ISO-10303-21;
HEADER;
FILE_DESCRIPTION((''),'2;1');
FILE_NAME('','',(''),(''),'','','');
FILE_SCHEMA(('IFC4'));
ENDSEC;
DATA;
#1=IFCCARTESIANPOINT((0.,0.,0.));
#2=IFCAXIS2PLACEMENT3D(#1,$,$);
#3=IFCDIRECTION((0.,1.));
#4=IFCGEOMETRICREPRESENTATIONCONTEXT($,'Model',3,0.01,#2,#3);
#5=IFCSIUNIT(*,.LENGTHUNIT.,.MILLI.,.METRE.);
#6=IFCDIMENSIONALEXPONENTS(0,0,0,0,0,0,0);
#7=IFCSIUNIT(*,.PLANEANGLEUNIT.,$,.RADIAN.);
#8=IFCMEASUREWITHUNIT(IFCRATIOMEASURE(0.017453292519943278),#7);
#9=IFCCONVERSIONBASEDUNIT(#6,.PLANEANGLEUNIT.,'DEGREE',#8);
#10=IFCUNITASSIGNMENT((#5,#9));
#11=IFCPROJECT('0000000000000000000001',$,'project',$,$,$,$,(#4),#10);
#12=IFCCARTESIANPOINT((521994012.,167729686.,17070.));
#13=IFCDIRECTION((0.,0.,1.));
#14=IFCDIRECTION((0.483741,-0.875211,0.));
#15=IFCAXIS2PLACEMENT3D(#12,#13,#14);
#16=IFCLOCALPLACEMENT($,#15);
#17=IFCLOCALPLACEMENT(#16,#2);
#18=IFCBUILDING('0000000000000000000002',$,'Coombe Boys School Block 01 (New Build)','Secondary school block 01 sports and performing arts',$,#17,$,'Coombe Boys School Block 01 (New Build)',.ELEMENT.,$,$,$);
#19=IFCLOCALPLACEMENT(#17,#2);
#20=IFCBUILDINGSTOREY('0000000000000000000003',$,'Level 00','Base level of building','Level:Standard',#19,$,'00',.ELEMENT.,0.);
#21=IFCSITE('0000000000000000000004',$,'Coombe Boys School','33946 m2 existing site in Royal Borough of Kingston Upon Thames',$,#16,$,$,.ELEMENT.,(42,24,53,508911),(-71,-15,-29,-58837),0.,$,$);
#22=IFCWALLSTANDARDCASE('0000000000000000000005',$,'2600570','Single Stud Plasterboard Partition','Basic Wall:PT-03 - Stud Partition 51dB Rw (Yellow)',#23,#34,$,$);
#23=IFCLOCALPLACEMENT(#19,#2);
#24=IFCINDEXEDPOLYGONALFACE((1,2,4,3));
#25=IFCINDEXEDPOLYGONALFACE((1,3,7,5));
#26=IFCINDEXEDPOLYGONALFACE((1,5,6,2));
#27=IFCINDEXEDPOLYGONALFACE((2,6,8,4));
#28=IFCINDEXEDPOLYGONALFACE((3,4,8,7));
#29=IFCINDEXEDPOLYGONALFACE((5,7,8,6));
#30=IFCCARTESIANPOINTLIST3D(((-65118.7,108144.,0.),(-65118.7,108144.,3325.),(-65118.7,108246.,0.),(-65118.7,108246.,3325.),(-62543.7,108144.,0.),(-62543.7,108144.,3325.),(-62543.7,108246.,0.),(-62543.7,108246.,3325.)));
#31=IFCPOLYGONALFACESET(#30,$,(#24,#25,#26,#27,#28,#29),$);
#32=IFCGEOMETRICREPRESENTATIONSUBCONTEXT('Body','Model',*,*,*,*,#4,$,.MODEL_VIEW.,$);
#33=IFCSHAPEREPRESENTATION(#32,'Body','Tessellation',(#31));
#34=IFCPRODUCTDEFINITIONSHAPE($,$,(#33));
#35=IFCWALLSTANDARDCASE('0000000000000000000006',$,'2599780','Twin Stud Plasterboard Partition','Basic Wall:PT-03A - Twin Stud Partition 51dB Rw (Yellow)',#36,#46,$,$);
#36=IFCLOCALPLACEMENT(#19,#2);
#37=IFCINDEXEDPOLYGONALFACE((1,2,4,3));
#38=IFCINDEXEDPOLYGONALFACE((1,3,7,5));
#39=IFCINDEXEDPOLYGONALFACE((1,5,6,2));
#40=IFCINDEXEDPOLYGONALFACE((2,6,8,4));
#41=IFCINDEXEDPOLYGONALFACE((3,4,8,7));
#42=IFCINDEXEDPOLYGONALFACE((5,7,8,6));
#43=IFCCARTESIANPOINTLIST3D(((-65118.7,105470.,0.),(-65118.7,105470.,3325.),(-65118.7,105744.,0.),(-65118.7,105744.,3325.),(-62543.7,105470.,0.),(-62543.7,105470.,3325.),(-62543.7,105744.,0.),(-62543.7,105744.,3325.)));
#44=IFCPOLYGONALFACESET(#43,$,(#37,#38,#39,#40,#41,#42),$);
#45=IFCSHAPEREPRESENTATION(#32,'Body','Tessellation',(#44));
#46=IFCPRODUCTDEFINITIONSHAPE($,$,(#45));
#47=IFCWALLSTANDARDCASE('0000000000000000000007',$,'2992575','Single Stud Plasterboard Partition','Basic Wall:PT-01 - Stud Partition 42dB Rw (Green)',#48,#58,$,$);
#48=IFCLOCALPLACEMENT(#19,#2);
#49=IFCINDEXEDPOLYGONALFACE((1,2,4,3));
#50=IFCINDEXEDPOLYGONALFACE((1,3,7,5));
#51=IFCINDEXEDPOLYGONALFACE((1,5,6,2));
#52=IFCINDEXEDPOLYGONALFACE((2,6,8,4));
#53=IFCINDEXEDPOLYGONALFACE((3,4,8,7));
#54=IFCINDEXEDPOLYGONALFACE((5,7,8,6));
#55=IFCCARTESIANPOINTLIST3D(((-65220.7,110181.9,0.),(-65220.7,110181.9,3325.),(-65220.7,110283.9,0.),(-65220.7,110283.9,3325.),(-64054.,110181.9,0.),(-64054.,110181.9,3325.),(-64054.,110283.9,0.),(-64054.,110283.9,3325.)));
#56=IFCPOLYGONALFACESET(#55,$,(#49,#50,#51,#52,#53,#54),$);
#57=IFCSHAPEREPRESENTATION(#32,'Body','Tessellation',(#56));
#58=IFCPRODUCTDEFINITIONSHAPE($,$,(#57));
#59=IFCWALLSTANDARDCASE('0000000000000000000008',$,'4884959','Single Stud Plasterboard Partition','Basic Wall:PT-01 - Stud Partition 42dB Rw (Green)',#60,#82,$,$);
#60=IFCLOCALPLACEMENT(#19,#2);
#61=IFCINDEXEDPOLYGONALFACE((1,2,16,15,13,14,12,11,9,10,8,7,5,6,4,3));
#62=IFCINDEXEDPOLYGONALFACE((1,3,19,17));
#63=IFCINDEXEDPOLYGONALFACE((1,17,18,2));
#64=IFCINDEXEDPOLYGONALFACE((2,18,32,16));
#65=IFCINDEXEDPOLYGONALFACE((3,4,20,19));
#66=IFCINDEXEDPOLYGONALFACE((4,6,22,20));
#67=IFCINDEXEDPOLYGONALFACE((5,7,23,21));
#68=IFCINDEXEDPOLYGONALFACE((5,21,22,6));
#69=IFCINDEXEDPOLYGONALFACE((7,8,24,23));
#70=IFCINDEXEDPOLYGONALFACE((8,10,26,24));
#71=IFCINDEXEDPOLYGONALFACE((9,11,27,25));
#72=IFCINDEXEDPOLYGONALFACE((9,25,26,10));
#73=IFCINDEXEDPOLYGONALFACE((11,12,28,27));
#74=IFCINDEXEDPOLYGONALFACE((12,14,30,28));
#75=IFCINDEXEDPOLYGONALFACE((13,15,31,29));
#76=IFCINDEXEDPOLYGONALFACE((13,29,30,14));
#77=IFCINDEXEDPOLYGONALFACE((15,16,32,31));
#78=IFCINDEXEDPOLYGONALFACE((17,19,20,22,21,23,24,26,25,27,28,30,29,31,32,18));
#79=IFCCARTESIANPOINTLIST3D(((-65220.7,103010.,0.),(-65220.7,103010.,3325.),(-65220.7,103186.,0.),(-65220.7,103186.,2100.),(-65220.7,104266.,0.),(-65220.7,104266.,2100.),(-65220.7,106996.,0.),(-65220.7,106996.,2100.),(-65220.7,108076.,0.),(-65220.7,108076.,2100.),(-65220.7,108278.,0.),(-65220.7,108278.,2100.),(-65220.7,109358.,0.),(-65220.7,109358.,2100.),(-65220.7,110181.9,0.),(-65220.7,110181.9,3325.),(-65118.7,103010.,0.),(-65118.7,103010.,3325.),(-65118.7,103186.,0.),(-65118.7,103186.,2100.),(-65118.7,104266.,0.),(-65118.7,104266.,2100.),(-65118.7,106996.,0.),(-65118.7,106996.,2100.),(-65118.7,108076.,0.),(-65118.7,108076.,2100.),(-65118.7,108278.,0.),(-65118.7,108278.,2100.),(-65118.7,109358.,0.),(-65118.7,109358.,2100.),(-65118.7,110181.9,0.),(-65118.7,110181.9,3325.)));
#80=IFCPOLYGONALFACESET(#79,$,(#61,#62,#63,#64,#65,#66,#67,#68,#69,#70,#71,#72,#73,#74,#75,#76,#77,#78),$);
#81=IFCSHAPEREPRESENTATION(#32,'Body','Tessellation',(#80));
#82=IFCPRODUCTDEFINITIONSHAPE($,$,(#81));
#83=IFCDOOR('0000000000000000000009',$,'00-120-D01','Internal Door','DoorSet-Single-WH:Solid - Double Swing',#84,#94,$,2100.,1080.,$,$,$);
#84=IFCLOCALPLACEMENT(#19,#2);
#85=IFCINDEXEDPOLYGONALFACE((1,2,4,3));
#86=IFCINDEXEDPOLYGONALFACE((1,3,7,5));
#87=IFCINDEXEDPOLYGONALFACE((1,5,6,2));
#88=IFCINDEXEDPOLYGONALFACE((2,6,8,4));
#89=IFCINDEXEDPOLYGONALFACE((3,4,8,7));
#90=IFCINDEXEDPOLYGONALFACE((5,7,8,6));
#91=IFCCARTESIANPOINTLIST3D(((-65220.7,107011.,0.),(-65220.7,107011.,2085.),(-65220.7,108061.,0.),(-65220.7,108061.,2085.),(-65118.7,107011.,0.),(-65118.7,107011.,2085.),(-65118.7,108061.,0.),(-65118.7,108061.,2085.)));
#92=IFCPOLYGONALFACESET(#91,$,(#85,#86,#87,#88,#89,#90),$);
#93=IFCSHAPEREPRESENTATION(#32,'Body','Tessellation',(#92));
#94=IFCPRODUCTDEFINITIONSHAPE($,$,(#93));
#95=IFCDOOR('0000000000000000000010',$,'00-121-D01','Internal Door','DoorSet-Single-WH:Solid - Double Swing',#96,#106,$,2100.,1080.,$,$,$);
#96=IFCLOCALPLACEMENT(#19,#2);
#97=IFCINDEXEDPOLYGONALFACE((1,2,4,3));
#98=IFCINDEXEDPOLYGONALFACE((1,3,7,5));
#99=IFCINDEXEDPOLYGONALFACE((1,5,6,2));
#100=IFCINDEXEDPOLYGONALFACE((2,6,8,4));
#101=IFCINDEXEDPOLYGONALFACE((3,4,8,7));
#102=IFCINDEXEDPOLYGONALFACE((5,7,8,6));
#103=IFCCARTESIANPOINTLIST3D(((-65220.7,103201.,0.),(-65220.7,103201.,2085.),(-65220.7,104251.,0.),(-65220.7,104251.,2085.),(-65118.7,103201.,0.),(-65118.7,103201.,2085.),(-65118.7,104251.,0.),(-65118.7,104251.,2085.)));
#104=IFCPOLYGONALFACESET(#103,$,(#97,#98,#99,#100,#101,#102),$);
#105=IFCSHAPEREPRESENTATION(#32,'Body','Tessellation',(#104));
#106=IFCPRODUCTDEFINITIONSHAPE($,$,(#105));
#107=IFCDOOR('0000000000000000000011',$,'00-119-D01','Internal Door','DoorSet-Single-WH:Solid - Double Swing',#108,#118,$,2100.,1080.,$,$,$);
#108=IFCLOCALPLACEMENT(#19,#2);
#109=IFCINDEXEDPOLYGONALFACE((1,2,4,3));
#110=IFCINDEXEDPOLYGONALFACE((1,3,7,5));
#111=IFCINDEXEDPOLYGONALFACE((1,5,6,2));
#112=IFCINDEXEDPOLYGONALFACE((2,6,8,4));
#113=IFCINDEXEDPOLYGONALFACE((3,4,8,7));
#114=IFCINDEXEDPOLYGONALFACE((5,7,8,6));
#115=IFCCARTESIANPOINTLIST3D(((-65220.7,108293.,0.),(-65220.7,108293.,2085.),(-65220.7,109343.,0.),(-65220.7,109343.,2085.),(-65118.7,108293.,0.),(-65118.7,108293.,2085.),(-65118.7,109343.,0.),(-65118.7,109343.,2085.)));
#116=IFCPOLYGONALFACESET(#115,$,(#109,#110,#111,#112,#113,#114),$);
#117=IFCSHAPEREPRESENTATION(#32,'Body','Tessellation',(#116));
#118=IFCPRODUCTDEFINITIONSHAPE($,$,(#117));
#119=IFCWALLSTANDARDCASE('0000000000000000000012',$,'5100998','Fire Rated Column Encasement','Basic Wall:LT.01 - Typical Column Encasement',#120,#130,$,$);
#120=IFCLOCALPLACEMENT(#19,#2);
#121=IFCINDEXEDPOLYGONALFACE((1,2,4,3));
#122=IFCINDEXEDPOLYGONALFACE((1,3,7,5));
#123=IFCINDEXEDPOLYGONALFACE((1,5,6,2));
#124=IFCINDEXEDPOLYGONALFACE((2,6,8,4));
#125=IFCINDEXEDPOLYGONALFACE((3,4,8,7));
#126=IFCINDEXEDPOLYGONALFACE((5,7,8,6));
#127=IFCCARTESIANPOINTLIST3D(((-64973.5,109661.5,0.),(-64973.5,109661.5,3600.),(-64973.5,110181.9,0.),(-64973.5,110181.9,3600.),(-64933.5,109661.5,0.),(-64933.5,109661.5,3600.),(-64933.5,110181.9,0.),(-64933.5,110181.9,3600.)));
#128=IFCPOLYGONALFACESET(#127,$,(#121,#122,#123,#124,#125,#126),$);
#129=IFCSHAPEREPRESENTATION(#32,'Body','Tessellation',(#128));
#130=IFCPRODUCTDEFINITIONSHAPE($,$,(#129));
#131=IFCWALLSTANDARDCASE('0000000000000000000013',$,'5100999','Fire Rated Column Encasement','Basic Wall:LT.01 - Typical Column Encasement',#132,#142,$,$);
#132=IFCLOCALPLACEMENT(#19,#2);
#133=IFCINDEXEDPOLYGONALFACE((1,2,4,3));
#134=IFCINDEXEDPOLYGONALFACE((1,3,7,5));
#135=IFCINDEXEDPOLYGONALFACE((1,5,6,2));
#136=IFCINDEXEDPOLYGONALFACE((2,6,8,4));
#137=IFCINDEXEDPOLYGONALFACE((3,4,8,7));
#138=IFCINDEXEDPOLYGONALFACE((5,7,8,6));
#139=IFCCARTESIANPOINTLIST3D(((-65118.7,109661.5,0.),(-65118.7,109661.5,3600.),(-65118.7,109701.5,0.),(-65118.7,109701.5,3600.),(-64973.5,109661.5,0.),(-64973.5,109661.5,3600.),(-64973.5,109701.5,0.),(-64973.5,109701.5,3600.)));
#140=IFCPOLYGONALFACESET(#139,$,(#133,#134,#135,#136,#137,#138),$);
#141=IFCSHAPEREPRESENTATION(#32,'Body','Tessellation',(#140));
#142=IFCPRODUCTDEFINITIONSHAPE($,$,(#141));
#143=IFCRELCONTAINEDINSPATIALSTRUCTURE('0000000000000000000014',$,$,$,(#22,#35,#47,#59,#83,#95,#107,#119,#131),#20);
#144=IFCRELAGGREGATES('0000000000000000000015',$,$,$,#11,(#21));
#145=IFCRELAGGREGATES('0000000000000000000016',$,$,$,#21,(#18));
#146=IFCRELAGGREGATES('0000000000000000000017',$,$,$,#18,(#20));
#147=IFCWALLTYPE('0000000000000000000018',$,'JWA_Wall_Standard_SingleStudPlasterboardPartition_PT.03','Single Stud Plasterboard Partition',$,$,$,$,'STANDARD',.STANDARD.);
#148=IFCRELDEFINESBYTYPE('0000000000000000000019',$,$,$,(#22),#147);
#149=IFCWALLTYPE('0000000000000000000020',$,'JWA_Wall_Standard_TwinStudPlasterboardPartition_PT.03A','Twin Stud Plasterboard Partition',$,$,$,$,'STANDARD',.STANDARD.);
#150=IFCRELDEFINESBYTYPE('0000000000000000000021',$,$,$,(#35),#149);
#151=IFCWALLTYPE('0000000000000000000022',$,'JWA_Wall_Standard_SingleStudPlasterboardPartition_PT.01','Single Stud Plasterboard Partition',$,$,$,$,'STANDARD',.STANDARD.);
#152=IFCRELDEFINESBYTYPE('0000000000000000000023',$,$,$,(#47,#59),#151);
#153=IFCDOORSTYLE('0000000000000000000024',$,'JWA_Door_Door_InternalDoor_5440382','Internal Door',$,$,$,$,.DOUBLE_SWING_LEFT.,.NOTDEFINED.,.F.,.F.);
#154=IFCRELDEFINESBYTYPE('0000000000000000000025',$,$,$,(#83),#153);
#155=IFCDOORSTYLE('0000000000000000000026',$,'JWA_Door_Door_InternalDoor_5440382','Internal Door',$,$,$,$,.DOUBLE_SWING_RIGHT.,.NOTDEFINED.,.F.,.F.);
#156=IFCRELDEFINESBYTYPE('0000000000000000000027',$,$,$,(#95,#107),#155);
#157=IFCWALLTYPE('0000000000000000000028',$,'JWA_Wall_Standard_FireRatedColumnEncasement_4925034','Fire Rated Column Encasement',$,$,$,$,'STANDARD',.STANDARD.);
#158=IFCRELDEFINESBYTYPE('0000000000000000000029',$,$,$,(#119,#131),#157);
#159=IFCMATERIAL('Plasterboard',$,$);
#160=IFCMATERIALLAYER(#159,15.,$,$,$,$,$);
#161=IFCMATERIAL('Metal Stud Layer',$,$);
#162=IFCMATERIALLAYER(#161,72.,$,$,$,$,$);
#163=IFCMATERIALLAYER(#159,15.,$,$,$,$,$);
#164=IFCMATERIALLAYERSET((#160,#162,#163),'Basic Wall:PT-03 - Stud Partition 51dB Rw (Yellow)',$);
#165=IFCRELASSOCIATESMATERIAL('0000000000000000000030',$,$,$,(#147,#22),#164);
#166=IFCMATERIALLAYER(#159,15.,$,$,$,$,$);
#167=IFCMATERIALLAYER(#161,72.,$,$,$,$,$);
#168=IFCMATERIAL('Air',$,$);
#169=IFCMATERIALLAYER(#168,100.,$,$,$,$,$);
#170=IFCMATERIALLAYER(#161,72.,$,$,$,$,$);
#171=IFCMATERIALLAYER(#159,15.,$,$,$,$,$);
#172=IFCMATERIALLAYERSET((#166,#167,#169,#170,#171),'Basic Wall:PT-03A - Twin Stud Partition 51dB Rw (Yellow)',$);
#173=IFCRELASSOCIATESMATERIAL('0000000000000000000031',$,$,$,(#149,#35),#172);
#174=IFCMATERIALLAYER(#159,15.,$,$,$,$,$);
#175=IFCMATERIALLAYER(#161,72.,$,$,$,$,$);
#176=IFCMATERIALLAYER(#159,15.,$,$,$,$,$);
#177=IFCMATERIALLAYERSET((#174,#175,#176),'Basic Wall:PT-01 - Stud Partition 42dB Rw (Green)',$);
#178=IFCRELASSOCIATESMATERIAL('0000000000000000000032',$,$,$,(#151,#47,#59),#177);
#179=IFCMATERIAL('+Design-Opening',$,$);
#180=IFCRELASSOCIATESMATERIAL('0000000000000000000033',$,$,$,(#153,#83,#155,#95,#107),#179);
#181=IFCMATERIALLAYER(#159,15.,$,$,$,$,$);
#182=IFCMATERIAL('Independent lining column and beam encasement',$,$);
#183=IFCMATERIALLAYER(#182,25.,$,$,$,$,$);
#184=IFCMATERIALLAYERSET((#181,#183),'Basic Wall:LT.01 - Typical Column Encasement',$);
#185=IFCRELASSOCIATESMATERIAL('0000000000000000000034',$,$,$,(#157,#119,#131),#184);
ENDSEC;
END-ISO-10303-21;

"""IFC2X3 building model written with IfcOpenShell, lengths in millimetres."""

from ifc_helpers import new_model, entity, si_unit, converted_unit, direction, frame, frame_2d, origin, origin_2d_with_axis, place, context, subcontext, project, spatial, rectangle, extrude, source, transform, mapped, material, layer, layer_set, layer_usage, type_object, type_shapes, element, fill, save


model = new_model("IFC2X3")

# Units and contexts
model_context = context("Model", 3, precision=0.01, world=origin(), true_north=direction((0.0, 1.0)))
body_context = subcontext(model_context, "Body", "Model", "MODEL_VIEW")
ifc_project = project(units=[si_unit("LENGTHUNIT", "METRE", prefix="MILLI"), converted_unit("PLANEANGLEUNIT", "DEGREE", entity("IfcRatioMeasure", 0.017453292519943278), si_unit("PLANEANGLEUNIT", "RADIAN"), dimensions=[0, 0, 0, 0, 0, 0, 0])], contexts=[model_context])

# Site, building, storey
site_placement = place(None, frame((521994012.0, 167729686.0, 17070.0), z_axis=(0.0, 0.0, 1.0), x_axis=(0.483741, -0.875211, 0.0)))
site = spatial("IfcSite", under=ifc_project, at=site_placement, Name="Coombe Boys School", Description="33946 m2 existing site in Royal Borough of Kingston Upon Thames", CompositionType="ELEMENT", RefLatitude=(42, 24, 53, 508911), RefLongitude=(-71, -15, -29, -58837), RefElevation=0.0)
building_placement = place(site_placement, origin())
building = spatial("IfcBuilding", under=site, at=building_placement, Name="Coombe Boys School Block 01 (New Build)", Description="Secondary school block 01 sports and performing arts", LongName="Coombe Boys School Block 01 (New Build)", CompositionType="ELEMENT")
storey_placement = place(building_placement, origin())
storey = spatial("IfcBuildingStorey", under=building, at=storey_placement, Name="Level 00", Description="Base level of building", ObjectType="Level:Standard", LongName="00", CompositionType="ELEMENT", Elevation=0.0)

# Walls
ifc_material_1 = material(Name="Plasterboard")
ifc_layer_1 = layer(ifc_material_1, 15.0)
ifc_material_2 = material(Name="Metal Stud Layer")
ifc_layer_2 = layer(ifc_material_2, 72.0)
ifc_layer_3 = layer(ifc_material_1, 15.0)
ifc_layer_set_1 = layer_set([ifc_layer_1, ifc_layer_2, ifc_layer_3], Name="Basic Wall:PT-03 - Stud Partition 51dB Rw (Yellow)")
ifc_layer_usage_1 = layer_usage(ifc_layer_set_1, "AXIS2", "NEGATIVE", 51.0)
wall_type_1 = type_object("IfcWallType", Name="JWA_Wall_Standard_SingleStudPlasterboardPartition_PT.03", Description="Single Stud Plasterboard Partition", ElementType="STANDARD", PredefinedType="STANDARD", material=ifc_layer_set_1)
wall_1_placement = place(storey_placement, frame((-65118.7, 108195.0, 0.0)))
element("IfcWallStandardCase", 1, at=wall_1_placement, inside=storey, type_object=wall_type_1, material=ifc_layer_usage_1, Name="2600570", Description="Single Stud Plasterboard Partition", ObjectType="Basic Wall:PT-03 - Stud Partition 51dB Rw (Yellow)", context=body_context, shape_type="SweptSolid", body=[
    extrude(rectangle(XDim=2575.0, YDim=102.0, at=frame_2d((1287.5, 0.0), x_axis=(-1.0, 0.0))), origin(), (0.0, 0.0, 1.0), 3325.0),
])
ifc_layer_4 = layer(ifc_material_1, 15.0)
ifc_layer_5 = layer(ifc_material_2, 72.0)
ifc_material_3 = material(Name="Air")
ifc_layer_6 = layer(ifc_material_3, 100.0)
ifc_layer_7 = layer(ifc_material_2, 72.0)
ifc_layer_8 = layer(ifc_material_1, 15.0)
ifc_layer_set_2 = layer_set([ifc_layer_4, ifc_layer_5, ifc_layer_6, ifc_layer_7, ifc_layer_8], Name="Basic Wall:PT-03A - Twin Stud Partition 51dB Rw (Yellow)")
ifc_layer_usage_2 = layer_usage(ifc_layer_set_2, "AXIS2", "NEGATIVE", 137.0)
wall_type_2 = type_object("IfcWallType", Name="JWA_Wall_Standard_TwinStudPlasterboardPartition_PT.03A", Description="Twin Stud Plasterboard Partition", ElementType="STANDARD", PredefinedType="STANDARD", material=ifc_layer_set_2)
wall_2_placement = place(storey_placement, frame((-65118.7, 105607.0, 0.0)))
element("IfcWallStandardCase", 2, at=wall_2_placement, inside=storey, type_object=wall_type_2, material=ifc_layer_usage_2, Name="2599780", Description="Twin Stud Plasterboard Partition", ObjectType="Basic Wall:PT-03A - Twin Stud Partition 51dB Rw (Yellow)", context=body_context, shape_type="SweptSolid", body=[
    extrude(rectangle(XDim=2575.0, YDim=274.0, at=frame_2d((1287.5, 0.0), x_axis=(-1.0, 0.0))), origin(), (0.0, 0.0, 1.0), 3325.0),
])
ifc_layer_9 = layer(ifc_material_1, 15.0)
ifc_layer_10 = layer(ifc_material_2, 72.0)
ifc_layer_11 = layer(ifc_material_1, 15.0)
ifc_layer_set_3 = layer_set([ifc_layer_9, ifc_layer_10, ifc_layer_11], Name="Basic Wall:PT-01 - Stud Partition 42dB Rw (Green)")
ifc_layer_usage_3 = layer_usage(ifc_layer_set_3, "AXIS2", "NEGATIVE", 51.0)
wall_type_3 = type_object("IfcWallType", Name="JWA_Wall_Standard_SingleStudPlasterboardPartition_PT.01", Description="Single Stud Plasterboard Partition", ElementType="STANDARD", PredefinedType="STANDARD", material=ifc_layer_set_3)
wall_3_placement = place(storey_placement, frame((-65220.7, 110232.9, 0.0)))
element("IfcWallStandardCase", 3, at=wall_3_placement, inside=storey, type_object=wall_type_3, material=ifc_layer_usage_3, Name="2992575", Description="Single Stud Plasterboard Partition", ObjectType="Basic Wall:PT-01 - Stud Partition 42dB Rw (Green)", context=body_context, shape_type="SweptSolid", body=[
    extrude(rectangle(XDim=1166.8, YDim=102.0, at=frame_2d((583.4, 0.0), x_axis=(-1.0, 0.0))), origin(), (0.0, 0.0, 1.0), 3325.0),
])

# Wall, openings, doors
wall_4_placement = place(storey_placement, frame((-65169.7, 110181.9, 0.0), z_axis=(0.0, 0.0, 1.0), x_axis=(0.0, -1.0, 0.0)))
wall_4 = element("IfcWallStandardCase", 4, at=wall_4_placement, inside=storey, type_object=wall_type_3, material=ifc_layer_usage_3, Name="4884959", Description="Single Stud Plasterboard Partition", ObjectType="Basic Wall:PT-01 - Stud Partition 42dB Rw (Green)", context=body_context, shape_type="SweptSolid", body=[
    extrude(rectangle(XDim=7171.9, YDim=102.0, at=frame_2d((3585.9, 0.0), x_axis=(1.0, 0.0))), origin(), (0.0, 0.0, 1.0), 3325.0),
])
opening_1_placement = place(wall_4_placement, frame((110181.9, 65169.7, 0.0), z_axis=(0.0, 0.0, 1.0), x_axis=(0.0, 1.0, 0.0)))
opening_1 = element("IfcOpeningElement", 5, at=opening_1_placement, cuts=wall_4, ObjectType="Opening", context=body_context, shape_type="SweptSolid", body=[
    extrude(rectangle(XDim=2100.0, YDim=1080.0, at=frame_2d((0.0, 0.0), x_axis=(0.0, 1.0))), frame((-65220.7, 107536.0, 1050.0), z_axis=(1.0, 0.0, 0.0), x_axis=(0.0, -1.0, 0.0)), (0.0, 0.0, 1.0), 102.0),
])
opening_2_placement = place(wall_4_placement, frame((110181.9, 65169.7, 0.0), z_axis=(0.0, 0.0, 1.0), x_axis=(0.0, 1.0, 0.0)))
opening_2 = element("IfcOpeningElement", 6, at=opening_2_placement, cuts=wall_4, ObjectType="Opening", context=body_context, shape_type="SweptSolid", body=[
    extrude(rectangle(XDim=2100.0, YDim=1080.0, at=origin_2d_with_axis()), frame((-65220.7, 103726.0, 1050.0), z_axis=(1.0, 0.0, 0.0), x_axis=(0.0, 0.0, -1.0)), (0.0, 0.0, 1.0), 102.0),
])
opening_3_placement = place(wall_4_placement, frame((110181.9, 65169.7, 0.0), z_axis=(0.0, 0.0, 1.0), x_axis=(0.0, 1.0, 0.0)))
opening_3 = element("IfcOpeningElement", 7, at=opening_3_placement, cuts=wall_4, ObjectType="Opening", context=body_context, shape_type="SweptSolid", body=[
    extrude(rectangle(XDim=2100.0, YDim=1080.0, at=frame_2d((0.0, 0.0), x_axis=(1.0, 0.0))), frame((-65220.7, 108818.0, 1050.0), z_axis=(1.0, 0.0, 0.0), x_axis=(0.0, 0.0, -1.0)), (0.0, 0.0, 1.0), 102.0),
])
ifc_material_4 = material(Name="+Design-Opening")
door_style_1 = type_object("IfcDoorStyle", Name="JWA_Door_Door_InternalDoor_5440382", Description="Internal Door", ConstructionType="NOTDEFINED", OperationType="DOUBLE_SWING_LEFT", ParameterTakesPrecedence=False, Sizeable=False, material=ifc_material_4)
shared_shape_1 = source(origin(), body_context, "Body", "SweptSolid", [
    extrude(rectangle(XDim=1050.0, YDim=102.0, at=origin_2d_with_axis()), frame((125.0, 0.0, 0.0), z_axis=(0.0, 0.0, 1.0), x_axis=(-1.0, 0.0, 0.0)), (0.0, 0.0, 1.0), 2085.0),
])
type_shapes(door_style_1, [shared_shape_1])
door_1_placement = place(opening_1_placement, frame((-65169.7, 107411.0, 0.0), z_axis=(0.0, 0.0, 1.0), x_axis=(0.0, 1.0, 0.0)))
door_1 = element("IfcDoor", 8, at=door_1_placement, inside=storey, type_object=door_style_1, material=ifc_material_4, Name="00-120-D01", Description="Internal Door", ObjectType="DoorSet-Single-WH:Solid - Double Swing", OverallHeight=2100.0, OverallWidth=1080.0, context=body_context, shape_type="MappedRepresentation", body=[
    mapped(shared_shape_1, transform((0.0, 0.0, 0.0), scale=1.0)),
])
fill(opening_1, door_1)
door_style_2 = type_object("IfcDoorStyle", Name="JWA_Door_Door_InternalDoor_5440382", Description="Internal Door", ConstructionType="NOTDEFINED", OperationType="DOUBLE_SWING_RIGHT", ParameterTakesPrecedence=False, Sizeable=False, material=ifc_material_4)
shared_shape_2 = source(origin(), body_context, "Body", "SweptSolid", [
    extrude(rectangle(XDim=102.0, YDim=1050.0, at=origin_2d_with_axis()), frame((125.0, 0.0, 0.0), z_axis=(0.0, 0.0, 1.0), x_axis=(0.0, 1.0, 0.0)), (0.0, 0.0, 1.0), 2085.0),
])
type_shapes(door_style_2, [shared_shape_2])
door_2_placement = place(opening_2_placement, frame((-65169.7, 103851.0, 0.0), z_axis=(0.0, 0.0, 1.0), x_axis=(0.0, -1.0, 0.0)))
door_2 = element("IfcDoor", 9, at=door_2_placement, inside=storey, type_object=door_style_2, material=ifc_material_4, Name="00-121-D01", Description="Internal Door", ObjectType="DoorSet-Single-WH:Solid - Double Swing", OverallHeight=2100.0, OverallWidth=1080.0, context=body_context, shape_type="MappedRepresentation", body=[
    mapped(shared_shape_2, transform((0.0, 0.0, 0.0), scale=1.0)),
])
fill(opening_2, door_2)
door_3_placement = place(opening_3_placement, frame((-65169.7, 108943.0, 0.0), z_axis=(0.0, 0.0, 1.0), x_axis=(0.0, -1.0, 0.0)))
door_3 = element("IfcDoor", 10, at=door_3_placement, inside=storey, type_object=door_style_2, material=ifc_material_4, Name="00-119-D01", Description="Internal Door", ObjectType="DoorSet-Single-WH:Solid - Double Swing", OverallHeight=2100.0, OverallWidth=1080.0, context=body_context, shape_type="MappedRepresentation", body=[
    mapped(shared_shape_2, transform((0.0, 0.0, 0.0), scale=1.0)),
])
fill(opening_3, door_3)

# Walls
ifc_layer_12 = layer(ifc_material_1, 15.0)
ifc_material_5 = material(Name="Independent lining column and beam encasement")
ifc_layer_13 = layer(ifc_material_5, 25.0)
ifc_layer_set_4 = layer_set([ifc_layer_12, ifc_layer_13], Name="Basic Wall:LT.01 - Typical Column Encasement")
ifc_layer_usage_4 = layer_usage(ifc_layer_set_4, "AXIS2", "NEGATIVE", 20.0)
wall_type_4 = type_object("IfcWallType", Name="JWA_Wall_Standard_FireRatedColumnEncasement_4925034", Description="Fire Rated Column Encasement", ElementType="STANDARD", PredefinedType="STANDARD", material=ifc_layer_set_4)
wall_5_placement = place(storey_placement, frame((-64953.5, 110181.9, 0.0), z_axis=(0.0, 0.0, 1.0), x_axis=(0.0, -1.0, 0.0)))
element("IfcWallStandardCase", 11, at=wall_5_placement, inside=storey, type_object=wall_type_4, material=ifc_layer_usage_4, Name="5100998", Description="Fire Rated Column Encasement", ObjectType="Basic Wall:LT.01 - Typical Column Encasement", context=body_context, shape_type="SweptSolid", body=[
    extrude(rectangle(XDim=520.3, YDim=40.0, at=frame_2d((260.2, 0.0), x_axis=(-1.0, 0.0))), origin(), (0.0, 0.0, 1.0), 3600.0),
])
wall_6_placement = place(storey_placement, frame((-64973.5, 109681.5, 0.0), z_axis=(0.0, 0.0, 1.0), x_axis=(-1.0, 0.0, 0.0)))
element("IfcWallStandardCase", 12, at=wall_6_placement, inside=storey, type_object=wall_type_4, material=ifc_layer_usage_4, Name="5100999", Description="Fire Rated Column Encasement", ObjectType="Basic Wall:LT.01 - Typical Column Encasement", context=body_context, shape_type="SweptSolid", body=[
    extrude(rectangle(XDim=145.2, YDim=40.0, at=frame_2d((72.6, 0.0), x_axis=(-1.0, 0.0))), origin(), (0.0, 0.0, 1.0), 3600.0),
])

save(model, "model.ifc")
